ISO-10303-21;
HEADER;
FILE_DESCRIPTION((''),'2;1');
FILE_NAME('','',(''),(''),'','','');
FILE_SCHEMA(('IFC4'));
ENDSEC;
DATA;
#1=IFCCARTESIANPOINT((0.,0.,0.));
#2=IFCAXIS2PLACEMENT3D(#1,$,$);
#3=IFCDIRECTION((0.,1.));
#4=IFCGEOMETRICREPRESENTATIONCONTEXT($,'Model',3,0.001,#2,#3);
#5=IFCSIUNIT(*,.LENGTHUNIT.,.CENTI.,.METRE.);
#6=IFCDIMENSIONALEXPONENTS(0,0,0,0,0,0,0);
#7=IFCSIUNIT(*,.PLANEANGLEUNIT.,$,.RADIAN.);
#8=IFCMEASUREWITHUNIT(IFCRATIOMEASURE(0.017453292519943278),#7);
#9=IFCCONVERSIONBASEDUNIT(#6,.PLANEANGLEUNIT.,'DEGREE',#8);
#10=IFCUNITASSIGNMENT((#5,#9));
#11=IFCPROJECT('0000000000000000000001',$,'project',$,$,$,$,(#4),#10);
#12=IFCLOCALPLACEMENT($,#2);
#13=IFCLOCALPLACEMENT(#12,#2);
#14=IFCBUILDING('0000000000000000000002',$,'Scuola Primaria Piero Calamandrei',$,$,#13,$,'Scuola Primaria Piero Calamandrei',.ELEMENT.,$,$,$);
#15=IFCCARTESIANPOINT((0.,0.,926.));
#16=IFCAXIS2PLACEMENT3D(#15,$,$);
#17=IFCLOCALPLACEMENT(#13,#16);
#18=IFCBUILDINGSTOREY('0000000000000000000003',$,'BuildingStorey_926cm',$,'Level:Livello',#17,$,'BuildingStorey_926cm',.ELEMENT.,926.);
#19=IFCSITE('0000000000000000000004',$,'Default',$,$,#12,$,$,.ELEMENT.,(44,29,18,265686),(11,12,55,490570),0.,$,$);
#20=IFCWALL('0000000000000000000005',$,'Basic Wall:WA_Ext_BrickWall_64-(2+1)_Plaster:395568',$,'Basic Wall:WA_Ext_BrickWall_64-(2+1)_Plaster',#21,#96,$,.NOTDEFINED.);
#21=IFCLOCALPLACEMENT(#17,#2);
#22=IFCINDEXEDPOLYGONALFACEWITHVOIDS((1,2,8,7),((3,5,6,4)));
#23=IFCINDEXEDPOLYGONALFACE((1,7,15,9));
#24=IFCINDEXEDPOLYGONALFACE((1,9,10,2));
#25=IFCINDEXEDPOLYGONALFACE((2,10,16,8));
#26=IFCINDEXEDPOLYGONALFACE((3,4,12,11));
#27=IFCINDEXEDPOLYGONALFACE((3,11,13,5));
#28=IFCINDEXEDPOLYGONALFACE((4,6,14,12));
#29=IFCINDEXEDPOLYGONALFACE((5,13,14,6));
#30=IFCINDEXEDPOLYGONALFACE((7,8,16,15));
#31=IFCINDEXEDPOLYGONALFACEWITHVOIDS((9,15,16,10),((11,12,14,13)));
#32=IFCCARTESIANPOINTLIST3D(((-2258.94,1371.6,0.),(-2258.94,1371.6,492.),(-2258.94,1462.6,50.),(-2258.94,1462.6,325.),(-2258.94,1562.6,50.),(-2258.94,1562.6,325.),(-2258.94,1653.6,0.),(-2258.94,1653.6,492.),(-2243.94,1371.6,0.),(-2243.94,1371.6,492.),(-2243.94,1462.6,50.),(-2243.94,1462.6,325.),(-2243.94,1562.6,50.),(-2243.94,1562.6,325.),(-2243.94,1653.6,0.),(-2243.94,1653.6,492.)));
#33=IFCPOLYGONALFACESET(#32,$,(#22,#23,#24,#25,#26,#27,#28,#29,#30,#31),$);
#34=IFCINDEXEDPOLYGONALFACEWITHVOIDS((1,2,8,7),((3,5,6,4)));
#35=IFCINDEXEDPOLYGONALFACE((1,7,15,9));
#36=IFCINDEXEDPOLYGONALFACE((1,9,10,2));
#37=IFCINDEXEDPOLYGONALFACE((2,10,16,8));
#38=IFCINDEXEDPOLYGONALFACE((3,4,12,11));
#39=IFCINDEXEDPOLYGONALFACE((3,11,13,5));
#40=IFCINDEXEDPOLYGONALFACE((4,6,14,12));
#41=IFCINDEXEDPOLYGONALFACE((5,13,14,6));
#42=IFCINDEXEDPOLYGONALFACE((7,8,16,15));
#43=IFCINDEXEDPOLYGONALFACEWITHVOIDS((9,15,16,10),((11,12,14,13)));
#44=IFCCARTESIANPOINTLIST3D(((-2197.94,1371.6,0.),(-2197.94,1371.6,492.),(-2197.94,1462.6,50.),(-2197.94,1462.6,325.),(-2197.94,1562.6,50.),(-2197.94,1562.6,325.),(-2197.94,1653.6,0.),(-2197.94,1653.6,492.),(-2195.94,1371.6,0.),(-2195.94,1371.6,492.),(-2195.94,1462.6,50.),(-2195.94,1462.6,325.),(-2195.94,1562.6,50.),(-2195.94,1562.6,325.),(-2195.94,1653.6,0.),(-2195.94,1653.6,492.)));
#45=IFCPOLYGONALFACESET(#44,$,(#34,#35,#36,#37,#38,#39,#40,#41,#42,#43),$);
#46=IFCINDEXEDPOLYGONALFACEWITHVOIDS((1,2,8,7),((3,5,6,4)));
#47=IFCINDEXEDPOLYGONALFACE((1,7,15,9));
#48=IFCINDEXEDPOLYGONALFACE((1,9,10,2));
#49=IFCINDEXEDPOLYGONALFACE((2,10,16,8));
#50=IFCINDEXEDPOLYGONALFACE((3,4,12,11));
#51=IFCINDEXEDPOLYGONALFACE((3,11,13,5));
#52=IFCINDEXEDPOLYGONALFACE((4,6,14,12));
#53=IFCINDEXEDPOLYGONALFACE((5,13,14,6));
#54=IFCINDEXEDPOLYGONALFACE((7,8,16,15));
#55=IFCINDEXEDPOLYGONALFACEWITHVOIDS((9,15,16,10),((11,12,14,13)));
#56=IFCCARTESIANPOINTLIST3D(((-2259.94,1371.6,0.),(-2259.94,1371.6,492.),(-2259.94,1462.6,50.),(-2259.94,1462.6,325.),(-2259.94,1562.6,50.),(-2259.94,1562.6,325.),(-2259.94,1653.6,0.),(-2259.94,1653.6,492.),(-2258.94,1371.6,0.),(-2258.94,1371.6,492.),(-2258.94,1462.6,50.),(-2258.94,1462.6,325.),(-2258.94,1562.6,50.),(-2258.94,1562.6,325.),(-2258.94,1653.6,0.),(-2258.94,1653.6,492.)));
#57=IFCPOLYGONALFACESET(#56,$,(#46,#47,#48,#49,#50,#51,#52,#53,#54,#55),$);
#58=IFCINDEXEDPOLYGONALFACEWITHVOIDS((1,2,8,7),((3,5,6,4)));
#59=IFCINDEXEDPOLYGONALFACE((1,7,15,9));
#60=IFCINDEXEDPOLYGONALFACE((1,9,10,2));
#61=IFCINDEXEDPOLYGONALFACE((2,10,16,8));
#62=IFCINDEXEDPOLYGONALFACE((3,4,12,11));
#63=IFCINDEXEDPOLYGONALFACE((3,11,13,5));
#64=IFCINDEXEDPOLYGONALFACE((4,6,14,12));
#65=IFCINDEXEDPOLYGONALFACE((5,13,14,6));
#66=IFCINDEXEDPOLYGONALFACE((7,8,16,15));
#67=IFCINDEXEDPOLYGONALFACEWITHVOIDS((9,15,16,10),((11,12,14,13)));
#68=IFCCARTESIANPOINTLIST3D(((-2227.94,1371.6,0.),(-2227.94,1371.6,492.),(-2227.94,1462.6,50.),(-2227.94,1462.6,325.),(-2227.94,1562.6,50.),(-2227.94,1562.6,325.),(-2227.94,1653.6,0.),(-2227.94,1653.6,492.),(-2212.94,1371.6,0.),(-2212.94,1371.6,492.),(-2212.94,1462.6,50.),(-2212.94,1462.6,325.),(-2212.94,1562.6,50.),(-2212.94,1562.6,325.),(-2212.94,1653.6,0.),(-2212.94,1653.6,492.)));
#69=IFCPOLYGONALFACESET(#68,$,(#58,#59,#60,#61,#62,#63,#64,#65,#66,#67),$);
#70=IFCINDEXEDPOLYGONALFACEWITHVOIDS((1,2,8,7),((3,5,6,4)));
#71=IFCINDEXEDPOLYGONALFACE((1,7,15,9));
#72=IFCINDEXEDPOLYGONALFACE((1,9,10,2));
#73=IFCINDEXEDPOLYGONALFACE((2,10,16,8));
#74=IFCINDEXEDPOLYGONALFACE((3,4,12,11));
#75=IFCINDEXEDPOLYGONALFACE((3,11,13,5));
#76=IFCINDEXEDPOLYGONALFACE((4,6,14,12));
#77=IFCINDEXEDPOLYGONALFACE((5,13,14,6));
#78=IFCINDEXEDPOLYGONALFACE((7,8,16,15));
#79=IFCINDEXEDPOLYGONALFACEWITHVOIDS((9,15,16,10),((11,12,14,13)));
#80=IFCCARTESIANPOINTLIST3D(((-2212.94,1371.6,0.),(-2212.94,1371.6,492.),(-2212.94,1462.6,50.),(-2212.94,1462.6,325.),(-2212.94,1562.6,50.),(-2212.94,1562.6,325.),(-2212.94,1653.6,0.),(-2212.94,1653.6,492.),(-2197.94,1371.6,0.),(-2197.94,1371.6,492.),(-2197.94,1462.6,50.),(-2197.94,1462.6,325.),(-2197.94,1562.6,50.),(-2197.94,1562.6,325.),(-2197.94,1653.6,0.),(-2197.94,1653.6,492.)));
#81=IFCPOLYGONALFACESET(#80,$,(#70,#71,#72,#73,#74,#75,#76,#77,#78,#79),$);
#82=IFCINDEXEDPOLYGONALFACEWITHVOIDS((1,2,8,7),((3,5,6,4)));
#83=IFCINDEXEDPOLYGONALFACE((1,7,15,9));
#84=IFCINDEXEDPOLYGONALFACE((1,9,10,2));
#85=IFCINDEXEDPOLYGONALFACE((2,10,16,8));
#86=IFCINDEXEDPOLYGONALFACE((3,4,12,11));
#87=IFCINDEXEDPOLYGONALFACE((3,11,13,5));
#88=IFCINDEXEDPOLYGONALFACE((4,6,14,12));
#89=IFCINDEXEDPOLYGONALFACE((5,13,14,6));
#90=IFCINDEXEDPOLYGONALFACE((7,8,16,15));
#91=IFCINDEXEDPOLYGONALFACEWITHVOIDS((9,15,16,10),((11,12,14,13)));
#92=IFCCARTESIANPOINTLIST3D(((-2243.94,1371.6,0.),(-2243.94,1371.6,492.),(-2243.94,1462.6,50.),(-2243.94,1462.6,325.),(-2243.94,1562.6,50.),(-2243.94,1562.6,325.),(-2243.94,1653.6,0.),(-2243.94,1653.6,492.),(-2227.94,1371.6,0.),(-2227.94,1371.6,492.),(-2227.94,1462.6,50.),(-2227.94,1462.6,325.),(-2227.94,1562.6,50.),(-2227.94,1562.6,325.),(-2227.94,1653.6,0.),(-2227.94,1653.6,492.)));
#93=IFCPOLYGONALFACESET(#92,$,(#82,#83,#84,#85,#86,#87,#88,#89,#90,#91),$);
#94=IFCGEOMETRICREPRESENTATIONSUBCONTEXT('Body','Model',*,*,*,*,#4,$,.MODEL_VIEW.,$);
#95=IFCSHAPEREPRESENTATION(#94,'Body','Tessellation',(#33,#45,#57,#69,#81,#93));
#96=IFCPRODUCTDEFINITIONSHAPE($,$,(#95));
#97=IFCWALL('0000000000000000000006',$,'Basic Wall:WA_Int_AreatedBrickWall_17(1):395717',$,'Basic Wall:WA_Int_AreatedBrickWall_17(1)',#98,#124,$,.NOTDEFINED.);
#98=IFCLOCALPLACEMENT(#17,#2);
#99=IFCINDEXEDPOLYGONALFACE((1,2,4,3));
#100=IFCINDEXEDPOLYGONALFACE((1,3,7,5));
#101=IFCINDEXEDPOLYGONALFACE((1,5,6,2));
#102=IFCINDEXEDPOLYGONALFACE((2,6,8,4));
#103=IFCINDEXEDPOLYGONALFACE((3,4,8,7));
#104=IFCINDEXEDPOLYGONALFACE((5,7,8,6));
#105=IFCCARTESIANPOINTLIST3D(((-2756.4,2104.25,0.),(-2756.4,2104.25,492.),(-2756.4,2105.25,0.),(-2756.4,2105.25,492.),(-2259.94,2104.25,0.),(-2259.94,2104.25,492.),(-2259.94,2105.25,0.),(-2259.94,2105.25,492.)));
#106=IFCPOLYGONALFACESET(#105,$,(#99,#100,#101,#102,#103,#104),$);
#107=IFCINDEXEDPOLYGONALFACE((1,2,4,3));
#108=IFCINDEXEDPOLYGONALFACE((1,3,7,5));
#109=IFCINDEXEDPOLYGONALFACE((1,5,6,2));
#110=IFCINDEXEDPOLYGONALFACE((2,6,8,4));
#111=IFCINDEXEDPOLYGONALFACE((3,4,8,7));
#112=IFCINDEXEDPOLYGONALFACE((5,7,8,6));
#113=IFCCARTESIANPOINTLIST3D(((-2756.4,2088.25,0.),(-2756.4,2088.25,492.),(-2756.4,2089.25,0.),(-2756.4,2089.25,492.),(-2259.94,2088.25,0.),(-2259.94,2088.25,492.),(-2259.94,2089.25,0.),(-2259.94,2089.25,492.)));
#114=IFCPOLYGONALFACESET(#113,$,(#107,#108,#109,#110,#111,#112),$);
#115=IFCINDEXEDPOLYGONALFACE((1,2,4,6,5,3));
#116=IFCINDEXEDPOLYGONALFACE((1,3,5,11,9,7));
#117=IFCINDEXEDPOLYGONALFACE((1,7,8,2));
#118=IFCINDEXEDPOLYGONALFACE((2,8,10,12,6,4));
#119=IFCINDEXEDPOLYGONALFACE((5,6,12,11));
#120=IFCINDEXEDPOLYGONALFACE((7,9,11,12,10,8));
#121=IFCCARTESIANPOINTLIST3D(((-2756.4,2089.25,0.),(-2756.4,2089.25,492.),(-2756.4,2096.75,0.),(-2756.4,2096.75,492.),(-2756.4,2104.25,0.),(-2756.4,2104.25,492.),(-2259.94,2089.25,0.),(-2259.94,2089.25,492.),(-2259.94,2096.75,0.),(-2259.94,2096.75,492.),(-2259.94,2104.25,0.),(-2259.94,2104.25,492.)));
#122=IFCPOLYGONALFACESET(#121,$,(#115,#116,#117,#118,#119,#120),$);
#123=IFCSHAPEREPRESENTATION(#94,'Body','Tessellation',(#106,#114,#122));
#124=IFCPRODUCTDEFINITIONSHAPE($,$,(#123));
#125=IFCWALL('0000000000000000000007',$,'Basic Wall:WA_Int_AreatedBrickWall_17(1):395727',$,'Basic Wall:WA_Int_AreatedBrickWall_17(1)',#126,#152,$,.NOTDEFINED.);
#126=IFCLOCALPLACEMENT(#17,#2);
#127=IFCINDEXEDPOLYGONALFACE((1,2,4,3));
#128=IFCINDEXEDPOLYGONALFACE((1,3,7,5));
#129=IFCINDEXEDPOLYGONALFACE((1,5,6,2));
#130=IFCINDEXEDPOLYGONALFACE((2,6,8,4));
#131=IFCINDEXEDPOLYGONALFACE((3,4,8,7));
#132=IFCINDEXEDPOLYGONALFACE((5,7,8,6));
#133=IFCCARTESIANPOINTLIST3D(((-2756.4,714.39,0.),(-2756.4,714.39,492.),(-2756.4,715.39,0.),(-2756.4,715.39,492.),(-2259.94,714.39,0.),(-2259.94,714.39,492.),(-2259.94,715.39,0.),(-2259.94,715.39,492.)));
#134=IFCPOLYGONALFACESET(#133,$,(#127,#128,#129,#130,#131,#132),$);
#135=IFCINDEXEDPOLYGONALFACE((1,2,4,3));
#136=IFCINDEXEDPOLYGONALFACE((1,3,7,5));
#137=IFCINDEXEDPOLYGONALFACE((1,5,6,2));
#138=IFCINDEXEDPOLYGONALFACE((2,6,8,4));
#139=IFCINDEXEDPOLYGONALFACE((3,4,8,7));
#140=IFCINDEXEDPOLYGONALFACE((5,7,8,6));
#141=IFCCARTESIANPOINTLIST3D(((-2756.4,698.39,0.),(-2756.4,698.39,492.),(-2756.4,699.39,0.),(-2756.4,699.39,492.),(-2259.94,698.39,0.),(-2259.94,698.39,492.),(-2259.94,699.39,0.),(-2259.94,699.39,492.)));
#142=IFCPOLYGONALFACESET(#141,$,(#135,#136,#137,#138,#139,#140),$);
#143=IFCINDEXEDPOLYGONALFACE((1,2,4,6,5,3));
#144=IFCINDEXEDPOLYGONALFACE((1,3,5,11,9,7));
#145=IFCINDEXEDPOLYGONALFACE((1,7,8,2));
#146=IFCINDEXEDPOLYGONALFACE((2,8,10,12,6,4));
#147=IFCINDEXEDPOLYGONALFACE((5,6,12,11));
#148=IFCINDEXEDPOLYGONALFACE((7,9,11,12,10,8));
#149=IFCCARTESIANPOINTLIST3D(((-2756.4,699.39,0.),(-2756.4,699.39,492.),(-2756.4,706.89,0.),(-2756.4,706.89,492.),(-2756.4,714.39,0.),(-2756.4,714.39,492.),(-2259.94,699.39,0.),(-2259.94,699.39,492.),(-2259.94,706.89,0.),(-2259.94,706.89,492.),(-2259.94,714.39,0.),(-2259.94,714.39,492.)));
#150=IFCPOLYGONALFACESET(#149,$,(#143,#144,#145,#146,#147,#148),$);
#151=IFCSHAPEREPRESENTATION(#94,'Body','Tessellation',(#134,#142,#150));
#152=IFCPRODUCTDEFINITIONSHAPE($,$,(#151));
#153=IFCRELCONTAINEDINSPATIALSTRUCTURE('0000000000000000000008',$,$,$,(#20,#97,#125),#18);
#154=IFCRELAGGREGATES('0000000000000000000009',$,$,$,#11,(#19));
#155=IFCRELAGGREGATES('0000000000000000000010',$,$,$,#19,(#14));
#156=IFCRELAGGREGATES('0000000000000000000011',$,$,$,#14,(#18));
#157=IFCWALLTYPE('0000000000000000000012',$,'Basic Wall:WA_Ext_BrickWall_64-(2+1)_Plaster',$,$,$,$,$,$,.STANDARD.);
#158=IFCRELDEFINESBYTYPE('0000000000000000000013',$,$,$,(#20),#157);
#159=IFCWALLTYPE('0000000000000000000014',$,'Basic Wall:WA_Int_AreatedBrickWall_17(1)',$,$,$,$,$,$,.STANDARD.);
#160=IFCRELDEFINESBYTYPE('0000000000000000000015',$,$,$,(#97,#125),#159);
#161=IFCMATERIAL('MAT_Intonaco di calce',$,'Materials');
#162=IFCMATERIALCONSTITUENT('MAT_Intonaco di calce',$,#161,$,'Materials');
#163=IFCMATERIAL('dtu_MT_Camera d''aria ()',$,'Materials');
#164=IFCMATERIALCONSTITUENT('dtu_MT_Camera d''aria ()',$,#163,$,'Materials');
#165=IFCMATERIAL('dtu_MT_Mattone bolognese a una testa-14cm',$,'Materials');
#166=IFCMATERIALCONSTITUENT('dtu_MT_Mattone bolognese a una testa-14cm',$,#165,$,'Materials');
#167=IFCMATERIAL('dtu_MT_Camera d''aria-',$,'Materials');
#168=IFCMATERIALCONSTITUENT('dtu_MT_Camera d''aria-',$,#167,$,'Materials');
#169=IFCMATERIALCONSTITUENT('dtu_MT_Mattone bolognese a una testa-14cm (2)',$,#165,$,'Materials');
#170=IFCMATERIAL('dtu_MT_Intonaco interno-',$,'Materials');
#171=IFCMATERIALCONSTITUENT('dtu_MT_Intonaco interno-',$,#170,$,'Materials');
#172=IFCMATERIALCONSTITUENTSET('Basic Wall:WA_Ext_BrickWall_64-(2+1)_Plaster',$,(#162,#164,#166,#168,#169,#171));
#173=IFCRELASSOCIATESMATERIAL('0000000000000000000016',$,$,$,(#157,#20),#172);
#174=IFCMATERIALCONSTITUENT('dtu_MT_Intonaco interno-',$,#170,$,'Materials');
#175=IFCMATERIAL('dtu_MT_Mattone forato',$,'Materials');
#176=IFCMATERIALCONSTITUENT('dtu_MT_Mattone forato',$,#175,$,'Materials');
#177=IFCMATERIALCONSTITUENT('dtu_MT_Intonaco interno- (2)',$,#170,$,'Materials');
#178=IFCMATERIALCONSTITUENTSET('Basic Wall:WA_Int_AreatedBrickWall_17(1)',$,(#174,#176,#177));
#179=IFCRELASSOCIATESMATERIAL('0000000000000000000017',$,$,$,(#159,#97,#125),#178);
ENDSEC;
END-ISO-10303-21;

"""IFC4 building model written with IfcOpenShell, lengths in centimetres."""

from ifc_helpers import new_model, entity, si_unit, converted_unit, direction, frame, origin, place, context, subcontext, project, spatial, indexed_curve, outline, extrude, material, constituent, constituent_set, type_object, element, save


model = new_model("IFC4")

# Units and contexts
model_context = context("Model", 3, precision=0.001, world=origin(), true_north=direction((0.0, 1.0)))
body_context = subcontext(model_context, "Body", "Model", "MODEL_VIEW")
ifc_project = project(units=[si_unit("LENGTHUNIT", "METRE", prefix="CENTI"), converted_unit("PLANEANGLEUNIT", "DEGREE", entity("IfcRatioMeasure", 0.017453292519943278), si_unit("PLANEANGLEUNIT", "RADIAN"), dimensions=[0, 0, 0, 0, 0, 0, 0])], contexts=[model_context])

# Site, building, storey
site_placement = place(None, origin())
site = spatial("IfcSite", under=ifc_project, at=site_placement, Name="Default", CompositionType="ELEMENT", RefLatitude=(44, 29, 18, 265686), RefLongitude=(11, 12, 55, 490570), RefElevation=0.0)
building_placement = place(site_placement, origin())
building = spatial("IfcBuilding", under=site, at=building_placement, Name="Scuola Primaria Piero Calamandrei", LongName="Scuola Primaria Piero Calamandrei", CompositionType="ELEMENT")
storey_placement = place(building_placement, frame((0.0, 0.0, 926.0)))
storey = spatial("IfcBuildingStorey", under=building, at=storey_placement, Name="BuildingStorey_926cm", ObjectType="Level:Livello", LongName="BuildingStorey_926cm", CompositionType="ELEMENT", Elevation=926.0)

# Wall, opening
ifc_material_1 = material(Name="MAT_Intonaco di calce", Category="Materials")
ifc_constituent_1 = constituent(ifc_material_1, Name="MAT_Intonaco di calce", Category="Materials")
ifc_material_2 = material(Name="dtu_MT_Camera d'aria ()", Category="Materials")
ifc_constituent_2 = constituent(ifc_material_2, Name="dtu_MT_Camera d'aria ()", Category="Materials")
ifc_material_3 = material(Name="dtu_MT_Mattone bolognese a una testa-14cm", Category="Materials")
ifc_constituent_3 = constituent(ifc_material_3, Name="dtu_MT_Mattone bolognese a una testa-14cm", Category="Materials")
ifc_material_4 = material(Name="dtu_MT_Camera d'aria-", Category="Materials")
ifc_constituent_4 = constituent(ifc_material_4, Name="dtu_MT_Camera d'aria-", Category="Materials")
ifc_constituent_5 = constituent(ifc_material_3, Name="dtu_MT_Mattone bolognese a una testa-14cm (2)", Category="Materials")
ifc_material_5 = material(Name="dtu_MT_Intonaco interno-", Category="Materials")
ifc_constituent_6 = constituent(ifc_material_5, Name="dtu_MT_Intonaco interno-", Category="Materials")
ifc_constituent_set_1 = constituent_set(constituents=[ifc_constituent_1, ifc_constituent_2, ifc_constituent_3, ifc_constituent_4, ifc_constituent_5, ifc_constituent_6], Name="Basic Wall:WA_Ext_BrickWall_64-(2+1)_Plaster")
wall_type_1 = type_object("IfcWallType", Name="Basic Wall:WA_Ext_BrickWall_64-(2+1)_Plaster", PredefinedType="STANDARD", material=ifc_constituent_set_1)
wall_1_placement = place(storey_placement, frame((-2227.94, 1653.6, 0.0), z_axis=(0.0, 0.0, 1.0), x_axis=(0.0, -1.0, 0.0)))
wall_1 = element("IfcWall", 1, at=wall_1_placement, inside=storey, type_object=wall_type_1, material=ifc_constituent_set_1, Name="Basic Wall:WA_Ext_BrickWall_64-(2+1)_Plaster:395568", ObjectType="Basic Wall:WA_Ext_BrickWall_64-(2+1)_Plaster", PredefinedType="NOTDEFINED", context=body_context, shape_type="SweptSolid", body=[
    extrude(outline(indexed_curve([(-246.0, -141.0), (246.0, -141.0), (246.0, 141.0), (-246.0, 141.0), (-246.0, -141.0)], self_intersect=False), holes=[indexed_curve([(-196.0, -50.0), (-196.0, 50.0), (79.0, 50.0), (79.0, -50.0), (-196.0, -50.0)], self_intersect=False)]), frame((141.0, -31.0, 246.0), z_axis=(0.0, 1.0, 0.0), x_axis=(0.0, 0.0, 1.0)), (0.0, 0.0, 1.0), 15.0),
    extrude(outline(indexed_curve([(-246.0, -141.0), (246.0, -141.0), (246.0, 141.0), (-246.0, 141.0), (-246.0, -141.0)], self_intersect=False), holes=[indexed_curve([(-196.0, -50.0), (-196.0, 50.0), (79.0, 50.0), (79.0, -50.0), (-196.0, -50.0)], self_intersect=False)]), frame((141.0, 30.0, 246.0), z_axis=(0.0, 1.0, 0.0), x_axis=(0.0, 0.0, 1.0)), (0.0, 0.0, 1.0), 2.0),
    extrude(outline(indexed_curve([(-246.0, -141.0), (246.0, -141.0), (246.0, -132.5), (246.0, 132.5), (246.0, 141.0), (-246.0, 141.0), (-246.0, 132.5), (-246.0, -132.5), (-246.0, -141.0)], self_intersect=False), holes=[indexed_curve([(79.0, -50.0), (-196.0, -50.0), (-196.0, 50.0), (79.0, 50.0), (79.0, -50.0)], self_intersect=False)]), frame((141.0, -32.0, 246.0), z_axis=(0.0, 1.0, 0.0), x_axis=(0.0, 0.0, 1.0)), (0.0, 0.0, 1.0), 1.0),
    extrude(outline(indexed_curve([(-246.0, -141.0), (246.0, -141.0), (246.0, 141.0), (-246.0, 141.0), (-246.0, -141.0)], self_intersect=False), holes=[indexed_curve([(-196.0, -50.0), (-196.0, 50.0), (79.0, 50.0), (79.0, -50.0), (-196.0, -50.0)], self_intersect=False)]), frame((141.0, 0.0, 246.0), z_axis=(0.0, 1.0, 0.0), x_axis=(0.0, 0.0, 1.0)), (0.0, 0.0, 1.0), 15.0),
    extrude(outline(indexed_curve([(-246.0, -141.0), (246.0, -141.0), (246.0, 141.0), (-246.0, 141.0), (-246.0, -141.0)], self_intersect=False), holes=[indexed_curve([(-196.0, -50.0), (-196.0, 50.0), (79.0, 50.0), (79.0, -50.0), (-196.0, -50.0)], self_intersect=False)]), frame((141.0, 15.0, 246.0), z_axis=(0.0, 1.0, 0.0), x_axis=(0.0, 0.0, 1.0)), (0.0, 0.0, 1.0), 15.0),
    extrude(outline(indexed_curve([(-246.0, -141.0), (246.0, -141.0), (246.0, 141.0), (-246.0, 141.0), (-246.0, -141.0)], self_intersect=False), holes=[indexed_curve([(-196.0, -50.0), (-196.0, 50.0), (79.0, 50.0), (79.0, -50.0), (-196.0, -50.0)], self_intersect=False)]), frame((141.0, -16.0, 246.0), z_axis=(0.0, 1.0, 0.0), x_axis=(0.0, 0.0, 1.0)), (0.0, 0.0, 1.0), 16.0),
])
opening_1_placement = place(wall_1_placement, frame((91.0, -32.0, 50.0)))
element("IfcOpeningElement", 2, at=opening_1_placement, cuts=wall_1, PredefinedType="OPENING", context=body_context, shape_type="SweptSolid", body=[
    extrude(outline(indexed_curve([(275.0, 0.0), (275.0, 100.0), (0.0, 100.0), (0.0, 0.0), (275.0, 0.0)], self_intersect=False)), frame((0.0, 0.0, 0.0), z_axis=(0.0, 1.0, 0.0), x_axis=(0.0, 0.0, 1.0)), (0.0, 0.0, 1.0), 64.0),
])

# Walls
ifc_constituent_7 = constituent(ifc_material_5, Name="dtu_MT_Intonaco interno-", Category="Materials")
ifc_material_6 = material(Name="dtu_MT_Mattone forato", Category="Materials")
ifc_constituent_8 = constituent(ifc_material_6, Name="dtu_MT_Mattone forato", Category="Materials")
ifc_constituent_9 = constituent(ifc_material_5, Name="dtu_MT_Intonaco interno- (2)", Category="Materials")
ifc_constituent_set_2 = constituent_set(constituents=[ifc_constituent_7, ifc_constituent_8, ifc_constituent_9], Name="Basic Wall:WA_Int_AreatedBrickWall_17(1)")
wall_type_2 = type_object("IfcWallType", Name="Basic Wall:WA_Int_AreatedBrickWall_17(1)", PredefinedType="STANDARD", material=ifc_constituent_set_2)
wall_2_placement = place(storey_placement, frame((-2259.94, 2096.75, 0.0), z_axis=(0.0, 0.0, 1.0), x_axis=(-1.0, 0.0, 0.0)))
element("IfcWall", 3, at=wall_2_placement, inside=storey, type_object=wall_type_2, material=ifc_constituent_set_2, Name="Basic Wall:WA_Int_AreatedBrickWall_17(1):395717", ObjectType="Basic Wall:WA_Int_AreatedBrickWall_17(1)", PredefinedType="NOTDEFINED", context=body_context, shape_type="SweptSolid", body=[
    extrude(outline(indexed_curve([(-0.5, -248.23), (0.5, -248.23), (0.5, 248.23), (-0.5, 248.23), (-0.5, -248.23)], self_intersect=False)), frame((248.23, -8.0, 0.0), z_axis=(0.0, 0.0, 1.0), x_axis=(0.0, 1.0, 0.0)), (0.0, 0.0, 1.0), 492.0),
    extrude(outline(indexed_curve([(-0.5, -248.23), (0.5, -248.23), (0.5, 248.23), (-0.5, 248.23), (-0.5, -248.23)], self_intersect=False)), frame((248.23, 8.0, 0.0), z_axis=(0.0, 0.0, 1.0), x_axis=(0.0, -1.0, 0.0)), (0.0, 0.0, 1.0), 492.0),
    extrude(outline(indexed_curve([(-248.23, -7.5), (248.23, -7.5), (248.23, 0.0), (248.23, 7.5), (-248.23, 7.5), (-248.23, 0.0), (-248.23, -7.5)], self_intersect=False)), frame((248.23, 0.0, 0.0)), (0.0, 0.0, 1.0), 492.0),
])
wall_3_placement = place(storey_placement, frame((-2259.94, 706.89, 0.0), z_axis=(0.0, 0.0, 1.0), x_axis=(-1.0, 0.0, 0.0)))
element("IfcWall", 4, at=wall_3_placement, inside=storey, type_object=wall_type_2, material=ifc_constituent_set_2, Name="Basic Wall:WA_Int_AreatedBrickWall_17(1):395727", ObjectType="Basic Wall:WA_Int_AreatedBrickWall_17(1)", PredefinedType="NOTDEFINED", context=body_context, shape_type="SweptSolid", body=[
    extrude(outline(indexed_curve([(-0.5, -248.23), (0.5, -248.23), (0.5, 248.23), (-0.5, 248.23), (-0.5, -248.23)], self_intersect=False)), frame((248.23, -8.0, 0.0), z_axis=(0.0, 0.0, 1.0), x_axis=(0.0, 1.0, 0.0)), (0.0, 0.0, 1.0), 492.0),
    extrude(outline(indexed_curve([(-0.5, -248.23), (0.5, -248.23), (0.5, 248.23), (-0.5, 248.23), (-0.5, -248.23)], self_intersect=False)), frame((248.23, 8.0, 0.0), z_axis=(0.0, 0.0, 1.0), x_axis=(0.0, -1.0, 0.0)), (0.0, 0.0, 1.0), 492.0),
    extrude(outline(indexed_curve([(-248.23, -7.5), (248.23, -7.5), (248.23, 0.0), (248.23, 7.5), (-248.23, 7.5), (-248.23, 0.0), (-248.23, -7.5)], self_intersect=False)), frame((248.23, 0.0, 0.0)), (0.0, 0.0, 1.0), 492.0),
])

save(model, "model.ifc")
